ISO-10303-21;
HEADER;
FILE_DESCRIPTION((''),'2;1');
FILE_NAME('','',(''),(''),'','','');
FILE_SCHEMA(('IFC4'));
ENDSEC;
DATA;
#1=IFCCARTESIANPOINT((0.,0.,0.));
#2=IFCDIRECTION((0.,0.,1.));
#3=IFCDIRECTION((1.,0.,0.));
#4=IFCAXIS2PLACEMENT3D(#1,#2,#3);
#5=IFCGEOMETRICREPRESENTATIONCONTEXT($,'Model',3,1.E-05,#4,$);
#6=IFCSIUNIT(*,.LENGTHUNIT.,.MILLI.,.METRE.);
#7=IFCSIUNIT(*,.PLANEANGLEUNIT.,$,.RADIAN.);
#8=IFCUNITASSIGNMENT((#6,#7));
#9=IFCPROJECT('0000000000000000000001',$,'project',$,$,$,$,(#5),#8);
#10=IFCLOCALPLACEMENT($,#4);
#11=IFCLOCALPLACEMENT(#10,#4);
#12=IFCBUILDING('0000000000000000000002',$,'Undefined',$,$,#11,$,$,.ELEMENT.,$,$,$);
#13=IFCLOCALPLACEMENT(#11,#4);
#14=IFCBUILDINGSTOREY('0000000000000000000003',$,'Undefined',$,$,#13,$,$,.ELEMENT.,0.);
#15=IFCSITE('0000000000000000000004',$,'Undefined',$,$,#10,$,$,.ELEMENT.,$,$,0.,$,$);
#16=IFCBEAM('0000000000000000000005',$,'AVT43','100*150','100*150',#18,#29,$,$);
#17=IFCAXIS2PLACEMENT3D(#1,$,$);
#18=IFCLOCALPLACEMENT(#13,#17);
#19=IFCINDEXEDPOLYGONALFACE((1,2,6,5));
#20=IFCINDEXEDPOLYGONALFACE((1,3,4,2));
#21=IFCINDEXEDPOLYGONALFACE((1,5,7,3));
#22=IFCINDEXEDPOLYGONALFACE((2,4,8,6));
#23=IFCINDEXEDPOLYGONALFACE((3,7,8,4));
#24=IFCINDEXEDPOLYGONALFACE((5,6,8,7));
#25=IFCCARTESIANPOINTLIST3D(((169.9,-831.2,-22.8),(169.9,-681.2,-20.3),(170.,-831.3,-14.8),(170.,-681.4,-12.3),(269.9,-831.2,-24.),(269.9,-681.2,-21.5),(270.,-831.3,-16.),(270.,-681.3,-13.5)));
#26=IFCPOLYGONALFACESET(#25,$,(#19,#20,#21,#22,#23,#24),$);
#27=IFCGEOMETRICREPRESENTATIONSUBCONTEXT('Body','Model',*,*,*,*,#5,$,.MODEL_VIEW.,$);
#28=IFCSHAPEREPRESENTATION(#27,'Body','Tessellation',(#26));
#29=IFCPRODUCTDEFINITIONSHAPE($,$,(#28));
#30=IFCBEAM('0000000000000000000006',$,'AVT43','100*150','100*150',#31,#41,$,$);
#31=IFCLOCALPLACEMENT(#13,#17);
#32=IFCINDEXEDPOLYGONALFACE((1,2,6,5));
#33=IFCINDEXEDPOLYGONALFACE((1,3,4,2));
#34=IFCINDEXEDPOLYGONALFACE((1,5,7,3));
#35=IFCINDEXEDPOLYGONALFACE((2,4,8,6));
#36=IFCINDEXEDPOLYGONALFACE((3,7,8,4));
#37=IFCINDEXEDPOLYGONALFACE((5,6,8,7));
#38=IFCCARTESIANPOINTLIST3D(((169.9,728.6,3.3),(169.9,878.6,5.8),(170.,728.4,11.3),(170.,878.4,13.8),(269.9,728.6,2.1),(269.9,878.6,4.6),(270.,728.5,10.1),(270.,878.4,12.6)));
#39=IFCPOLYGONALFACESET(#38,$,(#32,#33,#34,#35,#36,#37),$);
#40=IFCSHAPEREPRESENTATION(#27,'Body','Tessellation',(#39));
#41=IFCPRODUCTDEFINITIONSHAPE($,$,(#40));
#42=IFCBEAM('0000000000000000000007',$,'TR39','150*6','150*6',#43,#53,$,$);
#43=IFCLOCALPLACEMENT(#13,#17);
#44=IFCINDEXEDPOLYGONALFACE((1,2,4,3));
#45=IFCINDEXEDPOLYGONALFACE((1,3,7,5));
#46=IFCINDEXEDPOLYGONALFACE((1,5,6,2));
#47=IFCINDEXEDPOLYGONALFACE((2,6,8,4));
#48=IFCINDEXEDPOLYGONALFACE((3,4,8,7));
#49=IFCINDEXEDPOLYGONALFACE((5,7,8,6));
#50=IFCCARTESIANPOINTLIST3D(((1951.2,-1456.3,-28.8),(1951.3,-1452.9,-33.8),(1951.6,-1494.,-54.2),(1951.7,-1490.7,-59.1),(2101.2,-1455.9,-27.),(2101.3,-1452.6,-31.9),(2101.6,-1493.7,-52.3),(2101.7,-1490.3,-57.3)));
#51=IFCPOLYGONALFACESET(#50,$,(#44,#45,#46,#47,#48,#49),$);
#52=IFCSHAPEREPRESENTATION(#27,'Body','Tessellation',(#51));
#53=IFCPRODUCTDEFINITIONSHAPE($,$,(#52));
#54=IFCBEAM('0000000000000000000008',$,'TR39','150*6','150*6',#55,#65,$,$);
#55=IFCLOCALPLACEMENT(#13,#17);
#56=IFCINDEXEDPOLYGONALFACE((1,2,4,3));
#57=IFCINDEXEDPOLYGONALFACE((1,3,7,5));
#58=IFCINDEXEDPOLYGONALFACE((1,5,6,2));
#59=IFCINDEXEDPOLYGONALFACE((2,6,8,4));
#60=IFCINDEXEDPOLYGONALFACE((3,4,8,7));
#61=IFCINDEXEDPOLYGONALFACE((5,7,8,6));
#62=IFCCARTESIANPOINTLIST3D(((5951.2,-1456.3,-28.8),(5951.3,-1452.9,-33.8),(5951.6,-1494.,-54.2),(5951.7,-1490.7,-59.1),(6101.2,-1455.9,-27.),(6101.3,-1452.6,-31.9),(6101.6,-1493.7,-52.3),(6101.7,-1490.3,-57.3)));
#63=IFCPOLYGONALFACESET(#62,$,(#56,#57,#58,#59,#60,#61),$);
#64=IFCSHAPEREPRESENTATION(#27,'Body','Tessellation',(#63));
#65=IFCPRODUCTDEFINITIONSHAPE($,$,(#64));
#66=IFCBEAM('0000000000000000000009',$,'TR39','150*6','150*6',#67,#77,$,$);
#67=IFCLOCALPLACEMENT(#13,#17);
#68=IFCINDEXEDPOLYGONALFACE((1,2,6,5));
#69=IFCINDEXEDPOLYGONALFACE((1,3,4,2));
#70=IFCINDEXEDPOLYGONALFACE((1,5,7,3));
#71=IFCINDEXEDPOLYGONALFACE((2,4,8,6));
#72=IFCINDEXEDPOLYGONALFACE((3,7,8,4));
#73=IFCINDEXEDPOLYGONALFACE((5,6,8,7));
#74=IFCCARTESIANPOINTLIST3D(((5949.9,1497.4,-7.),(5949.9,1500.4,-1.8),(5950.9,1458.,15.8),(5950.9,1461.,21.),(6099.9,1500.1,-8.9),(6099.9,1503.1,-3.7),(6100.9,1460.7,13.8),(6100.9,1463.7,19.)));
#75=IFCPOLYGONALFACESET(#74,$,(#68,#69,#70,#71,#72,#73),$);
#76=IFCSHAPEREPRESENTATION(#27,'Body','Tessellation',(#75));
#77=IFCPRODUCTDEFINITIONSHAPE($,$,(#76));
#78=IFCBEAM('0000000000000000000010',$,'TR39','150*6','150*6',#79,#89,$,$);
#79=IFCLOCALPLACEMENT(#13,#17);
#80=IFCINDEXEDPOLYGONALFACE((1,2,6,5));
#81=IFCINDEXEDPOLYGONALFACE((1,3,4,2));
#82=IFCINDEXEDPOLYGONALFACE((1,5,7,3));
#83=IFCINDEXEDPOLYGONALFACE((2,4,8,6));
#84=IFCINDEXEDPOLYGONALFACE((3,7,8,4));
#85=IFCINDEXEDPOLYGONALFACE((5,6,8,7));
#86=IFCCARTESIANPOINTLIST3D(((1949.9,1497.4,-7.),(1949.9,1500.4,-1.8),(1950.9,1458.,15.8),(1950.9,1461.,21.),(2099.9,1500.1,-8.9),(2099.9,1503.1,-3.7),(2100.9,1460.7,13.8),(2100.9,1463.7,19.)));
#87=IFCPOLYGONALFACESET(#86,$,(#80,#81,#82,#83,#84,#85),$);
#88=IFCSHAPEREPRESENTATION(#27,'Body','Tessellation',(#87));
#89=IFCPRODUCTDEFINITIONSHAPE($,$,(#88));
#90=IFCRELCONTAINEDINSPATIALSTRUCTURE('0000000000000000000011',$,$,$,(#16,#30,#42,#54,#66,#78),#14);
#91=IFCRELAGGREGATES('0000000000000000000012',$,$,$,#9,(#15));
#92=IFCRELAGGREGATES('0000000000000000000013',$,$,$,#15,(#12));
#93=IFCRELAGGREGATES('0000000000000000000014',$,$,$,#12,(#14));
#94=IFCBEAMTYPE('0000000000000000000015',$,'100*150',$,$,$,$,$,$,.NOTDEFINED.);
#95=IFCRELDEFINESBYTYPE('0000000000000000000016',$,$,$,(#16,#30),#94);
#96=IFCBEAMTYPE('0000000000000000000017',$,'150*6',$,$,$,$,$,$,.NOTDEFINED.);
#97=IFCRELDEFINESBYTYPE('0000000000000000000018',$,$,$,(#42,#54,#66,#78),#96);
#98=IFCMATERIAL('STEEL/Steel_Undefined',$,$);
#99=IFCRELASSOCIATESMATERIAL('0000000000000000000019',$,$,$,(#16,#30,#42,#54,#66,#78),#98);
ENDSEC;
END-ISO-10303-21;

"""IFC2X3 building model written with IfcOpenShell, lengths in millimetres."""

from ifc_helpers import new_model, si_unit, frame, origin_with_axes, origin_2d_with_axis, place, context, subcontext, project, spatial, rectangle, extrude, material, type_object, element, save


model = new_model("IFC2X3")

# Units and contexts
model_context = context("Model", 3, precision=1e-05, world=origin_with_axes())
body_context = subcontext(model_context, "Body", "Model", "MODEL_VIEW")
ifc_project = project(units=[si_unit("LENGTHUNIT", "METRE", prefix="MILLI"), si_unit("PLANEANGLEUNIT", "RADIAN")], contexts=[model_context])

# Site, building, storey
site_placement = place(None, origin_with_axes())
site = spatial("IfcSite", under=ifc_project, at=site_placement, Name="Undefined", CompositionType="ELEMENT", RefElevation=0.0)
building_placement = place(site_placement, origin_with_axes())
building = spatial("IfcBuilding", under=site, at=building_placement, Name="Undefined", CompositionType="ELEMENT")
storey_placement = place(building_placement, origin_with_axes())
storey = spatial("IfcBuildingStorey", under=building, at=storey_placement, Name="Undefined", CompositionType="ELEMENT", Elevation=0.0)

# Beams
ifc_material_1 = material(Name="STEEL/Steel_Undefined")
beam_type_1 = type_object("IfcBeamType", Name="100*150", PredefinedType="NOTDEFINED")
for number, where, z_axis, x_axis, name in (
    (1, (219.9, -756.2, -22.1), (0.999921, 0.000186, -0.012586), (0.012587, -0.016714, 0.999781), "AVT43"),
    (2, (219.9, 803.6, 3.9), (0.999921, 0.000186, -0.012586), (0.012587, -0.016714, 0.999781), "AVT43"),
):
    element("IfcBeam", number, at=place(storey_placement, frame(where, z_axis=z_axis, x_axis=x_axis)), inside=storey, type_object=beam_type_1, material=ifc_material_1, Name=name, Description="100*150", ObjectType="100*150", context=body_context, shape_type="SweptSolid", body=[
        extrude(rectangle(XDim=150.0, YDim=100.0, at=origin_2d_with_axis()), frame((8.0, 0.0, 0.0), z_axis=(-1.0, 0.0, 0.0), x_axis=(0.0, -1.0, 0.0)), (0.0, 0.0, 1.0), 8.0),
    ])
beam_type_2 = type_object("IfcBeamType", Name="150*6", PredefinedType="NOTDEFINED")
for number, where, z_axis, x_axis, name in (
    (3, (2026.6, -1492.2, -55.7), (-0.999922, -0.002351, -0.012227), (-0.008769, 0.83011, 0.557531), "TR39"),
    (4, (6026.6, -1492.2, -55.7), (-0.999922, -0.002351, -0.012227), (-0.008769, 0.83011, 0.557531), "TR39"),
):
    element("IfcBeam", number, at=place(storey_placement, frame(where, z_axis=z_axis, x_axis=x_axis)), inside=storey, type_object=beam_type_2, material=ifc_material_1, Name=name, Description="150*6", ObjectType="150*6", context=body_context, shape_type="SweptSolid", body=[
        extrude(rectangle(XDim=6.0, YDim=150.0, at=origin_2d_with_axis()), frame((45.5, 0.0, 0.0), z_axis=(-1.0, 0.0, 0.0), x_axis=(0.0, -1.0, 0.0)), (0.0, 0.0, 1.0), 45.5),
    ])
beam_1_placement = place(storey_placement, frame((6024.9, 1500.2, -5.4), z_axis=(0.999754, 0.018164, -0.012752), x_axis=(0.022108, -0.865485, 0.500446)))
element("IfcBeam", 5, at=beam_1_placement, inside=storey, type_object=beam_type_2, material=ifc_material_1, Name="TR39", Description="150*6", ObjectType="150*6", context=body_context, shape_type="SweptSolid", body=[
    extrude(rectangle(XDim=6.0, YDim=150.0, at=origin_2d_with_axis()), frame((45.5, 0.0, 0.0), z_axis=(-1.0, 0.0, 0.0), x_axis=(0.0, -1.0, 0.0)), (0.0, 0.0, 1.0), 45.5),
])
beam_2_placement = place(storey_placement, frame((2024.9, 1500.2, -5.4), z_axis=(0.999754, 0.018164, -0.012752), x_axis=(0.022108, -0.865485, 0.500446)))
element("IfcBeam", 6, at=beam_2_placement, inside=storey, type_object=beam_type_2, material=ifc_material_1, Name="TR39", Description="150*6", ObjectType="150*6", context=body_context, shape_type="SweptSolid", body=[
    extrude(rectangle(XDim=6.0, YDim=150.0, at=origin_2d_with_axis()), frame((45.5, 0.0, 0.0), z_axis=(-1.0, 0.0, 0.0), x_axis=(0.0, -1.0, 0.0)), (0.0, 0.0, 1.0), 45.5),
])

save(model, "model.ifc")
